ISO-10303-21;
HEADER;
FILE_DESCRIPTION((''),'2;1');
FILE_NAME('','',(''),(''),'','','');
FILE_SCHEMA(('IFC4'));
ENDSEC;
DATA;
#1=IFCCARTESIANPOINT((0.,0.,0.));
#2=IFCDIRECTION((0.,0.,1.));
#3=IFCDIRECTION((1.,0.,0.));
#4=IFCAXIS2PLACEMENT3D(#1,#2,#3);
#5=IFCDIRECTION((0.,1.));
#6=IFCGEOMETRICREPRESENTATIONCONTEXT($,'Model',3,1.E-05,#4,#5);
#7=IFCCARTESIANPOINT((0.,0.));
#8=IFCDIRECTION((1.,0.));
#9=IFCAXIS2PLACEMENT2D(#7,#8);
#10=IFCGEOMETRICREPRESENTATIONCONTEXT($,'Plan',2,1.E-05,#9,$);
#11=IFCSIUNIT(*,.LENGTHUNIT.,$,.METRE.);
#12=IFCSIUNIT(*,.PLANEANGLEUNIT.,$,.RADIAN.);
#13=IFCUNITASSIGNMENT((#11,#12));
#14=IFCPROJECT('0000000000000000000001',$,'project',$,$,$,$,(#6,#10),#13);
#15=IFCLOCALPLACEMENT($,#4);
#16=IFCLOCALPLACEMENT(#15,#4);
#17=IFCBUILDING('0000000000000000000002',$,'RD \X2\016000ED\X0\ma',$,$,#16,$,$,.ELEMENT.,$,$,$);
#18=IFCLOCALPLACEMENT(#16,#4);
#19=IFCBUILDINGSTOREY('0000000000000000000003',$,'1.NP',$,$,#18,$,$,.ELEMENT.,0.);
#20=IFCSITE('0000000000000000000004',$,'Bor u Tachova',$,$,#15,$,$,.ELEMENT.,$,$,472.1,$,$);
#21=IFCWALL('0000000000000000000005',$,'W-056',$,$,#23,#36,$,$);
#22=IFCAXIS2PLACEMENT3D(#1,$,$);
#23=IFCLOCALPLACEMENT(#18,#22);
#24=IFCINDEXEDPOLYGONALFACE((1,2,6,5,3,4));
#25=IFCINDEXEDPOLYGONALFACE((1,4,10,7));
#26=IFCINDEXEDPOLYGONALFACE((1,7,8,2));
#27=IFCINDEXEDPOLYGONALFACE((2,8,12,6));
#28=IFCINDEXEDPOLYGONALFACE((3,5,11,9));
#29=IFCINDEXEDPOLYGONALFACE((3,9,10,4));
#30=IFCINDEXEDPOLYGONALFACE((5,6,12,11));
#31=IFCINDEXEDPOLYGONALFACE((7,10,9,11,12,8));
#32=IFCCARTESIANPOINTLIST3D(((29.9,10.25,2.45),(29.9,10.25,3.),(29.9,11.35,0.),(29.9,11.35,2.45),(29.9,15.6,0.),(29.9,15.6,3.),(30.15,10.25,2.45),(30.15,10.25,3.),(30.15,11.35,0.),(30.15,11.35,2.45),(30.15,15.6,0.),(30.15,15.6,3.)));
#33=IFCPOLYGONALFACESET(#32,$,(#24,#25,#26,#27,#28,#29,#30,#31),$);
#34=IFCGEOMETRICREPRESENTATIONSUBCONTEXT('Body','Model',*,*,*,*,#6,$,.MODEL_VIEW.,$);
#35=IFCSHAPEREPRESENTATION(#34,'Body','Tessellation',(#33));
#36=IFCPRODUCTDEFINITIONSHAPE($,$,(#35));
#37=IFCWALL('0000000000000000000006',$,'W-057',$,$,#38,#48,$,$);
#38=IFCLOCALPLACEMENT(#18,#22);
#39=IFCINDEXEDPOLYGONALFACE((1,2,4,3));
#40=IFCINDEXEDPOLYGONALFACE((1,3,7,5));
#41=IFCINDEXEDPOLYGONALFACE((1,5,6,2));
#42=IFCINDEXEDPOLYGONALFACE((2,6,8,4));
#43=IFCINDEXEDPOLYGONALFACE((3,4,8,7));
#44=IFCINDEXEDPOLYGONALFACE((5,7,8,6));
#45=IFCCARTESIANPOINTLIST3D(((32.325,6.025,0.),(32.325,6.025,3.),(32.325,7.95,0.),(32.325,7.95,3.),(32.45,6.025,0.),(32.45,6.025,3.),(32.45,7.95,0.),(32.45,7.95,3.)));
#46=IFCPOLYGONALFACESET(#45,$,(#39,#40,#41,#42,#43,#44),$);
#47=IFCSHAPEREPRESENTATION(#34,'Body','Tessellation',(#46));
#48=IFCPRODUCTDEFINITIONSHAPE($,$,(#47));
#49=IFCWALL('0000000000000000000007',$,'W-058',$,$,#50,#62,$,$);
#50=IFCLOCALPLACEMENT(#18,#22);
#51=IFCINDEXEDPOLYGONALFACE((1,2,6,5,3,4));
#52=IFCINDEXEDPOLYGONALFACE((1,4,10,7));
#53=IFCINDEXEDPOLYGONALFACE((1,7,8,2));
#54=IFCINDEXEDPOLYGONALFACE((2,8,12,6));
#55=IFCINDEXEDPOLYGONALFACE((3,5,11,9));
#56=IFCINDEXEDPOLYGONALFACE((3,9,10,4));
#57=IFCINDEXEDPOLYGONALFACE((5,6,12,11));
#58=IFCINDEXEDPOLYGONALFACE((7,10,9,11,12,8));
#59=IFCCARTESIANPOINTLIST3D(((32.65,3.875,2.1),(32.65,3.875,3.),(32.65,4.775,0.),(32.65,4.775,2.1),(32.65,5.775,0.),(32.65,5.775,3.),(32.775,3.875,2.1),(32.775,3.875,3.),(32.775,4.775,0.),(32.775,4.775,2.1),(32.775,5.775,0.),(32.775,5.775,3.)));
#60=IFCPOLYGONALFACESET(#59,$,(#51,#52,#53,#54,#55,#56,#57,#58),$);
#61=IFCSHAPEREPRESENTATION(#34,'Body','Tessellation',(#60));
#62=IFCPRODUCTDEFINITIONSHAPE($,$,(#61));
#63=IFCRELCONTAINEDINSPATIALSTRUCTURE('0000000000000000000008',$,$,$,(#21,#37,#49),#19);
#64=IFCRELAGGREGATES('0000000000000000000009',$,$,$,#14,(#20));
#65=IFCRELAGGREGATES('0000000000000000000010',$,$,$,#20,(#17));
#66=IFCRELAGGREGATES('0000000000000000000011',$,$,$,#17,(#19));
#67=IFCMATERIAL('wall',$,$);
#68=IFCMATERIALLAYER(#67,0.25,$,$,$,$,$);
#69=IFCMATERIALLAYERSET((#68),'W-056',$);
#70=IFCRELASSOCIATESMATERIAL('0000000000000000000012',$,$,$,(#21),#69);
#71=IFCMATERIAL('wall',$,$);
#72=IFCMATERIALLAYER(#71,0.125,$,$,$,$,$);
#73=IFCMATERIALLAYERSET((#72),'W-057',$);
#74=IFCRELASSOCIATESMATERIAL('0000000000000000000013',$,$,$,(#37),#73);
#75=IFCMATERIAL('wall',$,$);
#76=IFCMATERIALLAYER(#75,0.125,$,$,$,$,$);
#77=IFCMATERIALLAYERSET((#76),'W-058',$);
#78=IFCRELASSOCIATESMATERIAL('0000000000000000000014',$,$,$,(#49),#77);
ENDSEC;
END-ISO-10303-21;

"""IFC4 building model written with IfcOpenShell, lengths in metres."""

from ifc_helpers import new_model, si_unit, direction, frame, frame_2d, origin_with_axes, origin_2d_with_axis, place, context, subcontext, project, spatial, line, indexed_curve, rectangle, outline, extrude, material, layer, layer_set, layer_usage, element, save


model = new_model("IFC4")

# Units and contexts
model_context = context("Model", 3, precision=1e-05, world=origin_with_axes(), true_north=direction((0.0, 1.0)))
plan_context = context("Plan", 2, precision=1e-05, world=origin_2d_with_axis())
body_context = subcontext(model_context, "Body", "Model", "MODEL_VIEW")
ifc_project = project(units=[si_unit("LENGTHUNIT", "METRE"), si_unit("PLANEANGLEUNIT", "RADIAN")], contexts=[model_context, plan_context])

# Site, building, storey
site_placement = place(None, origin_with_axes())
site = spatial("IfcSite", under=ifc_project, at=site_placement, Name="Bor u Tachova", CompositionType="ELEMENT", RefElevation=472.1)
building_placement = place(site_placement, origin_with_axes())
building = spatial("IfcBuilding", under=site, at=building_placement, Name="RD Šíma", CompositionType="ELEMENT")
storey_placement = place(building_placement, origin_with_axes())
storey = spatial("IfcBuildingStorey", under=building, at=storey_placement, Name="1.NP", CompositionType="ELEMENT", Elevation=0.0)

# Wall, opening
ifc_material_1 = material(Name="wall")
ifc_layer_1 = layer(ifc_material_1, 0.25)
ifc_layer_set_1 = layer_set([ifc_layer_1], Name="W-056")
ifc_layer_usage_1 = layer_usage(ifc_layer_set_1, "AXIS2", "POSITIVE", -0.125)
wall_1_placement = place(storey_placement, frame((30.025, 10.25, 0.0), z_axis=(0.0, 0.0, 1.0), x_axis=(0.0, 1.0, 0.0)))
wall_1 = element("IfcWall", 1, at=wall_1_placement, inside=storey, material=ifc_layer_usage_1, Name="W-056", context=body_context, shape_type="SweptSolid", body=[
    extrude(outline(indexed_curve([(0.0, -0.125), (0.0, 0.125), (5.35, 0.125), (5.35, -0.125)], segments=[line(1, 2, 3, 4, 1)])), origin_with_axes(), (0.0, 0.0, 1.0), 3.0),
])
opening_1_placement = place(wall_1_placement, origin_with_axes())
element("IfcOpeningElement", 2, at=opening_1_placement, cuts=wall_1, PredefinedType="OPENING", context=body_context, shape_type="SweptSolid", body=[
    extrude(rectangle(XDim=1.1, YDim=0.25, at=frame_2d((0.55, 0.0))), origin_with_axes(), (0.0, 0.0, 1.0), 2.45),
])

# Wall
ifc_material_2 = material(Name="wall")
ifc_layer_2 = layer(ifc_material_2, 0.125)
ifc_layer_set_2 = layer_set([ifc_layer_2], Name="W-057")
ifc_layer_usage_2 = layer_usage(ifc_layer_set_2, "AXIS2", "POSITIVE", -0.0625)
wall_2_placement = place(storey_placement, frame((32.3875, 5.9, 0.0), z_axis=(0.0, 0.0, 1.0), x_axis=(0.0, 1.0, 0.0)))
element("IfcWall", 3, at=wall_2_placement, inside=storey, material=ifc_layer_usage_2, Name="W-057", context=body_context, shape_type="SweptSolid", body=[
    extrude(outline(indexed_curve([(0.125, -0.0625), (0.125, 0.0625), (2.05, 0.0625), (2.05, -0.0625)], segments=[line(1, 2, 3, 4, 1)])), origin_with_axes(), (0.0, 0.0, 1.0), 3.0),
])

# Wall, opening
ifc_material_3 = material(Name="wall")
ifc_layer_3 = layer(ifc_material_3, 0.125)
ifc_layer_set_3 = layer_set([ifc_layer_3], Name="W-058")
ifc_layer_usage_3 = layer_usage(ifc_layer_set_3, "AXIS2", "POSITIVE", -0.0625)
wall_3_placement = place(storey_placement, frame((32.7125, 3.875, 0.0), z_axis=(0.0, 0.0, 1.0), x_axis=(0.0, 1.0, 0.0)))
wall_3 = element("IfcWall", 4, at=wall_3_placement, inside=storey, material=ifc_layer_usage_3, Name="W-058", context=body_context, shape_type="SweptSolid", body=[
    extrude(outline(indexed_curve([(0.0, -0.0625), (0.0, 0.0625), (1.9, 0.0625), (1.9, -0.0625)], segments=[line(1, 2, 3, 4, 1)])), origin_with_axes(), (0.0, 0.0, 1.0), 3.0),
])
opening_2_placement = place(wall_3_placement, origin_with_axes())
element("IfcOpeningElement", 5, at=opening_2_placement, cuts=wall_3, PredefinedType="OPENING", context=body_context, shape_type="SweptSolid", body=[
    extrude(rectangle(XDim=0.9, YDim=0.125, at=frame_2d((0.45, 0.0))), origin_with_axes(), (0.0, 0.0, 1.0), 2.1),
])

save(model, "model.ifc")
